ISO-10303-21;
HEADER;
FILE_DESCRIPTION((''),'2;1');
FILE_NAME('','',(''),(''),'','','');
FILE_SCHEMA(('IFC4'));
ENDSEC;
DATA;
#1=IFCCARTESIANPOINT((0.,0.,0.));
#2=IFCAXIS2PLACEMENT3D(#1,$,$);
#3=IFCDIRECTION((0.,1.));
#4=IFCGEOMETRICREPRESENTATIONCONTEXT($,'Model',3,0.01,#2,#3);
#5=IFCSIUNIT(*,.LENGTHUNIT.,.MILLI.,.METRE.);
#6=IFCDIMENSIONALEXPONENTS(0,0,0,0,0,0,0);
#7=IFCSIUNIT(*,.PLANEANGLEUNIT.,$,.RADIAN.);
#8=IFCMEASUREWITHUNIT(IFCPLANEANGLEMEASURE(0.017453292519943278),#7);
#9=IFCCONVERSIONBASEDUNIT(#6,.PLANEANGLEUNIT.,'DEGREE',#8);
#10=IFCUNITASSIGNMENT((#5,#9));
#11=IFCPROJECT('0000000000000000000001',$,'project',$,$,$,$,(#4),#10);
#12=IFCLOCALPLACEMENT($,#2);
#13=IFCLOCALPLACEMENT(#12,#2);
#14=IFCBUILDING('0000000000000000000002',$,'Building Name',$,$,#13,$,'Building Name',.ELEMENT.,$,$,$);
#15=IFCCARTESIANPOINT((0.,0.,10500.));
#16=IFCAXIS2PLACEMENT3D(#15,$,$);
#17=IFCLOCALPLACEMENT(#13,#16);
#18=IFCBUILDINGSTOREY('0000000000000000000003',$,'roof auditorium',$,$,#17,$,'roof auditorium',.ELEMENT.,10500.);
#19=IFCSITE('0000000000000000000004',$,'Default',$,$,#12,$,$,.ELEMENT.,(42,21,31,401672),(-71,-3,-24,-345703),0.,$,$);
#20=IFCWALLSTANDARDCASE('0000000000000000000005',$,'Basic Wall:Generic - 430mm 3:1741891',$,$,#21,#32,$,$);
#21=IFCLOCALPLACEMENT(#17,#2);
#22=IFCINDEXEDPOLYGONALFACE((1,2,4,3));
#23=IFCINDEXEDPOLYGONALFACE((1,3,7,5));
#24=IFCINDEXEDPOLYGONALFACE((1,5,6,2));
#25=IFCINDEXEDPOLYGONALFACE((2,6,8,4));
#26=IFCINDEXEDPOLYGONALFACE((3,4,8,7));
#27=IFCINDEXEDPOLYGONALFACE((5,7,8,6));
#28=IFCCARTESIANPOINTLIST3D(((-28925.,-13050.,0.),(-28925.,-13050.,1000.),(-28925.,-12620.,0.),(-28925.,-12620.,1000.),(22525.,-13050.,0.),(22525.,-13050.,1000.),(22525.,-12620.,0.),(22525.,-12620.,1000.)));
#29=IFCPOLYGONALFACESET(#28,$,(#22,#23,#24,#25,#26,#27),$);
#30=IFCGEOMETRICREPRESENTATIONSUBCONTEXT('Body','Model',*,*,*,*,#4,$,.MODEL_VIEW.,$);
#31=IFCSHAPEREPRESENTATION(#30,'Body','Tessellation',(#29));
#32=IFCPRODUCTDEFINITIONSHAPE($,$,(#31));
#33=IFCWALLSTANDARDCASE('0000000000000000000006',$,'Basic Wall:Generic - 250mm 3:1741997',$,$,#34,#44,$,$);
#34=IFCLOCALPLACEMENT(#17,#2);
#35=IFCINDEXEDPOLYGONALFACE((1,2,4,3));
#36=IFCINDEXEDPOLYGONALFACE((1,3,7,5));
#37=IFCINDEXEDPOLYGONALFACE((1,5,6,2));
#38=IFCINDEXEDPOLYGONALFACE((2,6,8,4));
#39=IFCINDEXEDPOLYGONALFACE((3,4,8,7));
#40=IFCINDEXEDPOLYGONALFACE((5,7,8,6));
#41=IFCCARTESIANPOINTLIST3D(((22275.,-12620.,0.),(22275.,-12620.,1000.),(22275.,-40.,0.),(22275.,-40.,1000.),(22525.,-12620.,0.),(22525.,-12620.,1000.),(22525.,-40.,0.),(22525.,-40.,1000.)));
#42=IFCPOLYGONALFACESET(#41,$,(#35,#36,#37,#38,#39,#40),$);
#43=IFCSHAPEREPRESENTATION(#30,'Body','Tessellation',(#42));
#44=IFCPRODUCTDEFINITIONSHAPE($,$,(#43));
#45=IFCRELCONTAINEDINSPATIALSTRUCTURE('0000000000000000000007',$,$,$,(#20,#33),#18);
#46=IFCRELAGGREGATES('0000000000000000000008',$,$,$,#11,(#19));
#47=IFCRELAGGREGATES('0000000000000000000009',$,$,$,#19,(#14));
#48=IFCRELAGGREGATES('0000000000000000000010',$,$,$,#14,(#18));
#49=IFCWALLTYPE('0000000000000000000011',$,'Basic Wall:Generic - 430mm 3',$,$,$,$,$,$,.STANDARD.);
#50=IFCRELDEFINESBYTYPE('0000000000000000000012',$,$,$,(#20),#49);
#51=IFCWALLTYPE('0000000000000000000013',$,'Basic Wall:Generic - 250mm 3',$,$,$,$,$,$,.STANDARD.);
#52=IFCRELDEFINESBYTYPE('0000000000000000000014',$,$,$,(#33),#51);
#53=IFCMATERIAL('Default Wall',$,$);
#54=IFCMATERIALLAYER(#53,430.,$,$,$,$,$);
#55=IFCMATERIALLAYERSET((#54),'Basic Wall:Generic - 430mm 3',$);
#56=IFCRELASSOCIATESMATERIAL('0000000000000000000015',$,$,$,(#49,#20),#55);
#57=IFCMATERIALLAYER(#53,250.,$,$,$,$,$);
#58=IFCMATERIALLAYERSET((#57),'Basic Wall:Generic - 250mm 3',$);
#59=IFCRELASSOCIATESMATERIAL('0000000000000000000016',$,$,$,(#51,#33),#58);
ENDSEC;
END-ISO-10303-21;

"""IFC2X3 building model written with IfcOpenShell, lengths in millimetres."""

from ifc_helpers import new_model, entity, si_unit, converted_unit, direction, frame, frame_2d, origin, place, context, subcontext, project, spatial, rectangle, extrude, material, layer, layer_set, layer_usage, type_object, element, save


model = new_model("IFC2X3")

# Units and contexts
model_context = context("Model", 3, precision=0.01, world=origin(), true_north=direction((0.0, 1.0)))
body_context = subcontext(model_context, "Body", "Model", "MODEL_VIEW")
ifc_project = project(units=[si_unit("LENGTHUNIT", "METRE", prefix="MILLI"), converted_unit("PLANEANGLEUNIT", "DEGREE", entity("IfcPlaneAngleMeasure", 0.017453292519943278), si_unit("PLANEANGLEUNIT", "RADIAN"), dimensions=[0, 0, 0, 0, 0, 0, 0])], contexts=[model_context])

# Site, building, storey
site_placement = place(None, origin())
site = spatial("IfcSite", under=ifc_project, at=site_placement, Name="Default", CompositionType="ELEMENT", RefLatitude=(42, 21, 31, 401672), RefLongitude=(-71, -3, -24, -345703), RefElevation=0.0)
building_placement = place(site_placement, origin())
building = spatial("IfcBuilding", under=site, at=building_placement, Name="Building Name", LongName="Building Name", CompositionType="ELEMENT")
storey_placement = place(building_placement, frame((0.0, 0.0, 10500.0)))
storey = spatial("IfcBuildingStorey", under=building, at=storey_placement, Name="roof auditorium", LongName="roof auditorium", CompositionType="ELEMENT", Elevation=10500.0)

# Walls
ifc_material = material(Name="Default Wall")
ifc_layer_1 = layer(ifc_material, 430.0)
ifc_layer_set_1 = layer_set([ifc_layer_1], Name="Basic Wall:Generic - 430mm 3")
ifc_layer_usage_1 = layer_usage(ifc_layer_set_1, "AXIS2", "NEGATIVE", 215.0)
wall_type_1 = type_object("IfcWallType", Name="Basic Wall:Generic - 430mm 3", PredefinedType="STANDARD", material=ifc_layer_set_1)
wall_1_placement = place(storey_placement, frame((-28925.0, -12835.0, 0.0)))
element("IfcWallStandardCase", 1, at=wall_1_placement, inside=storey, type_object=wall_type_1, material=ifc_layer_usage_1, Name="Basic Wall:Generic - 430mm 3:1741891", context=body_context, shape_type="SweptSolid", body=[
    extrude(rectangle(XDim=51450.0, YDim=430.0, at=frame_2d((25725.0, 0.0), x_axis=(-1.0, 0.0))), origin(), (0.0, 0.0, 1.0), 1000.0),
])
ifc_layer_2 = layer(ifc_material, 250.0)
ifc_layer_set_2 = layer_set([ifc_layer_2], Name="Basic Wall:Generic - 250mm 3")
ifc_layer_usage_2 = layer_usage(ifc_layer_set_2, "AXIS2", "NEGATIVE", 125.0)
wall_type_2 = type_object("IfcWallType", Name="Basic Wall:Generic - 250mm 3", PredefinedType="STANDARD", material=ifc_layer_set_2)
wall_2_placement = place(storey_placement, frame((22400.0, -12620.0, 0.0), z_axis=(0.0, 0.0, 1.0), x_axis=(0.0, 1.0, 0.0)))
element("IfcWallStandardCase", 2, at=wall_2_placement, inside=storey, type_object=wall_type_2, material=ifc_layer_usage_2, Name="Basic Wall:Generic - 250mm 3:1741997", context=body_context, shape_type="SweptSolid", body=[
    extrude(rectangle(XDim=12580.0, YDim=250.0, at=frame_2d((6290.0, 0.0), x_axis=(-1.0, 0.0))), origin(), (0.0, 0.0, 1.0), 1000.0),
])

save(model, "model.ifc")
